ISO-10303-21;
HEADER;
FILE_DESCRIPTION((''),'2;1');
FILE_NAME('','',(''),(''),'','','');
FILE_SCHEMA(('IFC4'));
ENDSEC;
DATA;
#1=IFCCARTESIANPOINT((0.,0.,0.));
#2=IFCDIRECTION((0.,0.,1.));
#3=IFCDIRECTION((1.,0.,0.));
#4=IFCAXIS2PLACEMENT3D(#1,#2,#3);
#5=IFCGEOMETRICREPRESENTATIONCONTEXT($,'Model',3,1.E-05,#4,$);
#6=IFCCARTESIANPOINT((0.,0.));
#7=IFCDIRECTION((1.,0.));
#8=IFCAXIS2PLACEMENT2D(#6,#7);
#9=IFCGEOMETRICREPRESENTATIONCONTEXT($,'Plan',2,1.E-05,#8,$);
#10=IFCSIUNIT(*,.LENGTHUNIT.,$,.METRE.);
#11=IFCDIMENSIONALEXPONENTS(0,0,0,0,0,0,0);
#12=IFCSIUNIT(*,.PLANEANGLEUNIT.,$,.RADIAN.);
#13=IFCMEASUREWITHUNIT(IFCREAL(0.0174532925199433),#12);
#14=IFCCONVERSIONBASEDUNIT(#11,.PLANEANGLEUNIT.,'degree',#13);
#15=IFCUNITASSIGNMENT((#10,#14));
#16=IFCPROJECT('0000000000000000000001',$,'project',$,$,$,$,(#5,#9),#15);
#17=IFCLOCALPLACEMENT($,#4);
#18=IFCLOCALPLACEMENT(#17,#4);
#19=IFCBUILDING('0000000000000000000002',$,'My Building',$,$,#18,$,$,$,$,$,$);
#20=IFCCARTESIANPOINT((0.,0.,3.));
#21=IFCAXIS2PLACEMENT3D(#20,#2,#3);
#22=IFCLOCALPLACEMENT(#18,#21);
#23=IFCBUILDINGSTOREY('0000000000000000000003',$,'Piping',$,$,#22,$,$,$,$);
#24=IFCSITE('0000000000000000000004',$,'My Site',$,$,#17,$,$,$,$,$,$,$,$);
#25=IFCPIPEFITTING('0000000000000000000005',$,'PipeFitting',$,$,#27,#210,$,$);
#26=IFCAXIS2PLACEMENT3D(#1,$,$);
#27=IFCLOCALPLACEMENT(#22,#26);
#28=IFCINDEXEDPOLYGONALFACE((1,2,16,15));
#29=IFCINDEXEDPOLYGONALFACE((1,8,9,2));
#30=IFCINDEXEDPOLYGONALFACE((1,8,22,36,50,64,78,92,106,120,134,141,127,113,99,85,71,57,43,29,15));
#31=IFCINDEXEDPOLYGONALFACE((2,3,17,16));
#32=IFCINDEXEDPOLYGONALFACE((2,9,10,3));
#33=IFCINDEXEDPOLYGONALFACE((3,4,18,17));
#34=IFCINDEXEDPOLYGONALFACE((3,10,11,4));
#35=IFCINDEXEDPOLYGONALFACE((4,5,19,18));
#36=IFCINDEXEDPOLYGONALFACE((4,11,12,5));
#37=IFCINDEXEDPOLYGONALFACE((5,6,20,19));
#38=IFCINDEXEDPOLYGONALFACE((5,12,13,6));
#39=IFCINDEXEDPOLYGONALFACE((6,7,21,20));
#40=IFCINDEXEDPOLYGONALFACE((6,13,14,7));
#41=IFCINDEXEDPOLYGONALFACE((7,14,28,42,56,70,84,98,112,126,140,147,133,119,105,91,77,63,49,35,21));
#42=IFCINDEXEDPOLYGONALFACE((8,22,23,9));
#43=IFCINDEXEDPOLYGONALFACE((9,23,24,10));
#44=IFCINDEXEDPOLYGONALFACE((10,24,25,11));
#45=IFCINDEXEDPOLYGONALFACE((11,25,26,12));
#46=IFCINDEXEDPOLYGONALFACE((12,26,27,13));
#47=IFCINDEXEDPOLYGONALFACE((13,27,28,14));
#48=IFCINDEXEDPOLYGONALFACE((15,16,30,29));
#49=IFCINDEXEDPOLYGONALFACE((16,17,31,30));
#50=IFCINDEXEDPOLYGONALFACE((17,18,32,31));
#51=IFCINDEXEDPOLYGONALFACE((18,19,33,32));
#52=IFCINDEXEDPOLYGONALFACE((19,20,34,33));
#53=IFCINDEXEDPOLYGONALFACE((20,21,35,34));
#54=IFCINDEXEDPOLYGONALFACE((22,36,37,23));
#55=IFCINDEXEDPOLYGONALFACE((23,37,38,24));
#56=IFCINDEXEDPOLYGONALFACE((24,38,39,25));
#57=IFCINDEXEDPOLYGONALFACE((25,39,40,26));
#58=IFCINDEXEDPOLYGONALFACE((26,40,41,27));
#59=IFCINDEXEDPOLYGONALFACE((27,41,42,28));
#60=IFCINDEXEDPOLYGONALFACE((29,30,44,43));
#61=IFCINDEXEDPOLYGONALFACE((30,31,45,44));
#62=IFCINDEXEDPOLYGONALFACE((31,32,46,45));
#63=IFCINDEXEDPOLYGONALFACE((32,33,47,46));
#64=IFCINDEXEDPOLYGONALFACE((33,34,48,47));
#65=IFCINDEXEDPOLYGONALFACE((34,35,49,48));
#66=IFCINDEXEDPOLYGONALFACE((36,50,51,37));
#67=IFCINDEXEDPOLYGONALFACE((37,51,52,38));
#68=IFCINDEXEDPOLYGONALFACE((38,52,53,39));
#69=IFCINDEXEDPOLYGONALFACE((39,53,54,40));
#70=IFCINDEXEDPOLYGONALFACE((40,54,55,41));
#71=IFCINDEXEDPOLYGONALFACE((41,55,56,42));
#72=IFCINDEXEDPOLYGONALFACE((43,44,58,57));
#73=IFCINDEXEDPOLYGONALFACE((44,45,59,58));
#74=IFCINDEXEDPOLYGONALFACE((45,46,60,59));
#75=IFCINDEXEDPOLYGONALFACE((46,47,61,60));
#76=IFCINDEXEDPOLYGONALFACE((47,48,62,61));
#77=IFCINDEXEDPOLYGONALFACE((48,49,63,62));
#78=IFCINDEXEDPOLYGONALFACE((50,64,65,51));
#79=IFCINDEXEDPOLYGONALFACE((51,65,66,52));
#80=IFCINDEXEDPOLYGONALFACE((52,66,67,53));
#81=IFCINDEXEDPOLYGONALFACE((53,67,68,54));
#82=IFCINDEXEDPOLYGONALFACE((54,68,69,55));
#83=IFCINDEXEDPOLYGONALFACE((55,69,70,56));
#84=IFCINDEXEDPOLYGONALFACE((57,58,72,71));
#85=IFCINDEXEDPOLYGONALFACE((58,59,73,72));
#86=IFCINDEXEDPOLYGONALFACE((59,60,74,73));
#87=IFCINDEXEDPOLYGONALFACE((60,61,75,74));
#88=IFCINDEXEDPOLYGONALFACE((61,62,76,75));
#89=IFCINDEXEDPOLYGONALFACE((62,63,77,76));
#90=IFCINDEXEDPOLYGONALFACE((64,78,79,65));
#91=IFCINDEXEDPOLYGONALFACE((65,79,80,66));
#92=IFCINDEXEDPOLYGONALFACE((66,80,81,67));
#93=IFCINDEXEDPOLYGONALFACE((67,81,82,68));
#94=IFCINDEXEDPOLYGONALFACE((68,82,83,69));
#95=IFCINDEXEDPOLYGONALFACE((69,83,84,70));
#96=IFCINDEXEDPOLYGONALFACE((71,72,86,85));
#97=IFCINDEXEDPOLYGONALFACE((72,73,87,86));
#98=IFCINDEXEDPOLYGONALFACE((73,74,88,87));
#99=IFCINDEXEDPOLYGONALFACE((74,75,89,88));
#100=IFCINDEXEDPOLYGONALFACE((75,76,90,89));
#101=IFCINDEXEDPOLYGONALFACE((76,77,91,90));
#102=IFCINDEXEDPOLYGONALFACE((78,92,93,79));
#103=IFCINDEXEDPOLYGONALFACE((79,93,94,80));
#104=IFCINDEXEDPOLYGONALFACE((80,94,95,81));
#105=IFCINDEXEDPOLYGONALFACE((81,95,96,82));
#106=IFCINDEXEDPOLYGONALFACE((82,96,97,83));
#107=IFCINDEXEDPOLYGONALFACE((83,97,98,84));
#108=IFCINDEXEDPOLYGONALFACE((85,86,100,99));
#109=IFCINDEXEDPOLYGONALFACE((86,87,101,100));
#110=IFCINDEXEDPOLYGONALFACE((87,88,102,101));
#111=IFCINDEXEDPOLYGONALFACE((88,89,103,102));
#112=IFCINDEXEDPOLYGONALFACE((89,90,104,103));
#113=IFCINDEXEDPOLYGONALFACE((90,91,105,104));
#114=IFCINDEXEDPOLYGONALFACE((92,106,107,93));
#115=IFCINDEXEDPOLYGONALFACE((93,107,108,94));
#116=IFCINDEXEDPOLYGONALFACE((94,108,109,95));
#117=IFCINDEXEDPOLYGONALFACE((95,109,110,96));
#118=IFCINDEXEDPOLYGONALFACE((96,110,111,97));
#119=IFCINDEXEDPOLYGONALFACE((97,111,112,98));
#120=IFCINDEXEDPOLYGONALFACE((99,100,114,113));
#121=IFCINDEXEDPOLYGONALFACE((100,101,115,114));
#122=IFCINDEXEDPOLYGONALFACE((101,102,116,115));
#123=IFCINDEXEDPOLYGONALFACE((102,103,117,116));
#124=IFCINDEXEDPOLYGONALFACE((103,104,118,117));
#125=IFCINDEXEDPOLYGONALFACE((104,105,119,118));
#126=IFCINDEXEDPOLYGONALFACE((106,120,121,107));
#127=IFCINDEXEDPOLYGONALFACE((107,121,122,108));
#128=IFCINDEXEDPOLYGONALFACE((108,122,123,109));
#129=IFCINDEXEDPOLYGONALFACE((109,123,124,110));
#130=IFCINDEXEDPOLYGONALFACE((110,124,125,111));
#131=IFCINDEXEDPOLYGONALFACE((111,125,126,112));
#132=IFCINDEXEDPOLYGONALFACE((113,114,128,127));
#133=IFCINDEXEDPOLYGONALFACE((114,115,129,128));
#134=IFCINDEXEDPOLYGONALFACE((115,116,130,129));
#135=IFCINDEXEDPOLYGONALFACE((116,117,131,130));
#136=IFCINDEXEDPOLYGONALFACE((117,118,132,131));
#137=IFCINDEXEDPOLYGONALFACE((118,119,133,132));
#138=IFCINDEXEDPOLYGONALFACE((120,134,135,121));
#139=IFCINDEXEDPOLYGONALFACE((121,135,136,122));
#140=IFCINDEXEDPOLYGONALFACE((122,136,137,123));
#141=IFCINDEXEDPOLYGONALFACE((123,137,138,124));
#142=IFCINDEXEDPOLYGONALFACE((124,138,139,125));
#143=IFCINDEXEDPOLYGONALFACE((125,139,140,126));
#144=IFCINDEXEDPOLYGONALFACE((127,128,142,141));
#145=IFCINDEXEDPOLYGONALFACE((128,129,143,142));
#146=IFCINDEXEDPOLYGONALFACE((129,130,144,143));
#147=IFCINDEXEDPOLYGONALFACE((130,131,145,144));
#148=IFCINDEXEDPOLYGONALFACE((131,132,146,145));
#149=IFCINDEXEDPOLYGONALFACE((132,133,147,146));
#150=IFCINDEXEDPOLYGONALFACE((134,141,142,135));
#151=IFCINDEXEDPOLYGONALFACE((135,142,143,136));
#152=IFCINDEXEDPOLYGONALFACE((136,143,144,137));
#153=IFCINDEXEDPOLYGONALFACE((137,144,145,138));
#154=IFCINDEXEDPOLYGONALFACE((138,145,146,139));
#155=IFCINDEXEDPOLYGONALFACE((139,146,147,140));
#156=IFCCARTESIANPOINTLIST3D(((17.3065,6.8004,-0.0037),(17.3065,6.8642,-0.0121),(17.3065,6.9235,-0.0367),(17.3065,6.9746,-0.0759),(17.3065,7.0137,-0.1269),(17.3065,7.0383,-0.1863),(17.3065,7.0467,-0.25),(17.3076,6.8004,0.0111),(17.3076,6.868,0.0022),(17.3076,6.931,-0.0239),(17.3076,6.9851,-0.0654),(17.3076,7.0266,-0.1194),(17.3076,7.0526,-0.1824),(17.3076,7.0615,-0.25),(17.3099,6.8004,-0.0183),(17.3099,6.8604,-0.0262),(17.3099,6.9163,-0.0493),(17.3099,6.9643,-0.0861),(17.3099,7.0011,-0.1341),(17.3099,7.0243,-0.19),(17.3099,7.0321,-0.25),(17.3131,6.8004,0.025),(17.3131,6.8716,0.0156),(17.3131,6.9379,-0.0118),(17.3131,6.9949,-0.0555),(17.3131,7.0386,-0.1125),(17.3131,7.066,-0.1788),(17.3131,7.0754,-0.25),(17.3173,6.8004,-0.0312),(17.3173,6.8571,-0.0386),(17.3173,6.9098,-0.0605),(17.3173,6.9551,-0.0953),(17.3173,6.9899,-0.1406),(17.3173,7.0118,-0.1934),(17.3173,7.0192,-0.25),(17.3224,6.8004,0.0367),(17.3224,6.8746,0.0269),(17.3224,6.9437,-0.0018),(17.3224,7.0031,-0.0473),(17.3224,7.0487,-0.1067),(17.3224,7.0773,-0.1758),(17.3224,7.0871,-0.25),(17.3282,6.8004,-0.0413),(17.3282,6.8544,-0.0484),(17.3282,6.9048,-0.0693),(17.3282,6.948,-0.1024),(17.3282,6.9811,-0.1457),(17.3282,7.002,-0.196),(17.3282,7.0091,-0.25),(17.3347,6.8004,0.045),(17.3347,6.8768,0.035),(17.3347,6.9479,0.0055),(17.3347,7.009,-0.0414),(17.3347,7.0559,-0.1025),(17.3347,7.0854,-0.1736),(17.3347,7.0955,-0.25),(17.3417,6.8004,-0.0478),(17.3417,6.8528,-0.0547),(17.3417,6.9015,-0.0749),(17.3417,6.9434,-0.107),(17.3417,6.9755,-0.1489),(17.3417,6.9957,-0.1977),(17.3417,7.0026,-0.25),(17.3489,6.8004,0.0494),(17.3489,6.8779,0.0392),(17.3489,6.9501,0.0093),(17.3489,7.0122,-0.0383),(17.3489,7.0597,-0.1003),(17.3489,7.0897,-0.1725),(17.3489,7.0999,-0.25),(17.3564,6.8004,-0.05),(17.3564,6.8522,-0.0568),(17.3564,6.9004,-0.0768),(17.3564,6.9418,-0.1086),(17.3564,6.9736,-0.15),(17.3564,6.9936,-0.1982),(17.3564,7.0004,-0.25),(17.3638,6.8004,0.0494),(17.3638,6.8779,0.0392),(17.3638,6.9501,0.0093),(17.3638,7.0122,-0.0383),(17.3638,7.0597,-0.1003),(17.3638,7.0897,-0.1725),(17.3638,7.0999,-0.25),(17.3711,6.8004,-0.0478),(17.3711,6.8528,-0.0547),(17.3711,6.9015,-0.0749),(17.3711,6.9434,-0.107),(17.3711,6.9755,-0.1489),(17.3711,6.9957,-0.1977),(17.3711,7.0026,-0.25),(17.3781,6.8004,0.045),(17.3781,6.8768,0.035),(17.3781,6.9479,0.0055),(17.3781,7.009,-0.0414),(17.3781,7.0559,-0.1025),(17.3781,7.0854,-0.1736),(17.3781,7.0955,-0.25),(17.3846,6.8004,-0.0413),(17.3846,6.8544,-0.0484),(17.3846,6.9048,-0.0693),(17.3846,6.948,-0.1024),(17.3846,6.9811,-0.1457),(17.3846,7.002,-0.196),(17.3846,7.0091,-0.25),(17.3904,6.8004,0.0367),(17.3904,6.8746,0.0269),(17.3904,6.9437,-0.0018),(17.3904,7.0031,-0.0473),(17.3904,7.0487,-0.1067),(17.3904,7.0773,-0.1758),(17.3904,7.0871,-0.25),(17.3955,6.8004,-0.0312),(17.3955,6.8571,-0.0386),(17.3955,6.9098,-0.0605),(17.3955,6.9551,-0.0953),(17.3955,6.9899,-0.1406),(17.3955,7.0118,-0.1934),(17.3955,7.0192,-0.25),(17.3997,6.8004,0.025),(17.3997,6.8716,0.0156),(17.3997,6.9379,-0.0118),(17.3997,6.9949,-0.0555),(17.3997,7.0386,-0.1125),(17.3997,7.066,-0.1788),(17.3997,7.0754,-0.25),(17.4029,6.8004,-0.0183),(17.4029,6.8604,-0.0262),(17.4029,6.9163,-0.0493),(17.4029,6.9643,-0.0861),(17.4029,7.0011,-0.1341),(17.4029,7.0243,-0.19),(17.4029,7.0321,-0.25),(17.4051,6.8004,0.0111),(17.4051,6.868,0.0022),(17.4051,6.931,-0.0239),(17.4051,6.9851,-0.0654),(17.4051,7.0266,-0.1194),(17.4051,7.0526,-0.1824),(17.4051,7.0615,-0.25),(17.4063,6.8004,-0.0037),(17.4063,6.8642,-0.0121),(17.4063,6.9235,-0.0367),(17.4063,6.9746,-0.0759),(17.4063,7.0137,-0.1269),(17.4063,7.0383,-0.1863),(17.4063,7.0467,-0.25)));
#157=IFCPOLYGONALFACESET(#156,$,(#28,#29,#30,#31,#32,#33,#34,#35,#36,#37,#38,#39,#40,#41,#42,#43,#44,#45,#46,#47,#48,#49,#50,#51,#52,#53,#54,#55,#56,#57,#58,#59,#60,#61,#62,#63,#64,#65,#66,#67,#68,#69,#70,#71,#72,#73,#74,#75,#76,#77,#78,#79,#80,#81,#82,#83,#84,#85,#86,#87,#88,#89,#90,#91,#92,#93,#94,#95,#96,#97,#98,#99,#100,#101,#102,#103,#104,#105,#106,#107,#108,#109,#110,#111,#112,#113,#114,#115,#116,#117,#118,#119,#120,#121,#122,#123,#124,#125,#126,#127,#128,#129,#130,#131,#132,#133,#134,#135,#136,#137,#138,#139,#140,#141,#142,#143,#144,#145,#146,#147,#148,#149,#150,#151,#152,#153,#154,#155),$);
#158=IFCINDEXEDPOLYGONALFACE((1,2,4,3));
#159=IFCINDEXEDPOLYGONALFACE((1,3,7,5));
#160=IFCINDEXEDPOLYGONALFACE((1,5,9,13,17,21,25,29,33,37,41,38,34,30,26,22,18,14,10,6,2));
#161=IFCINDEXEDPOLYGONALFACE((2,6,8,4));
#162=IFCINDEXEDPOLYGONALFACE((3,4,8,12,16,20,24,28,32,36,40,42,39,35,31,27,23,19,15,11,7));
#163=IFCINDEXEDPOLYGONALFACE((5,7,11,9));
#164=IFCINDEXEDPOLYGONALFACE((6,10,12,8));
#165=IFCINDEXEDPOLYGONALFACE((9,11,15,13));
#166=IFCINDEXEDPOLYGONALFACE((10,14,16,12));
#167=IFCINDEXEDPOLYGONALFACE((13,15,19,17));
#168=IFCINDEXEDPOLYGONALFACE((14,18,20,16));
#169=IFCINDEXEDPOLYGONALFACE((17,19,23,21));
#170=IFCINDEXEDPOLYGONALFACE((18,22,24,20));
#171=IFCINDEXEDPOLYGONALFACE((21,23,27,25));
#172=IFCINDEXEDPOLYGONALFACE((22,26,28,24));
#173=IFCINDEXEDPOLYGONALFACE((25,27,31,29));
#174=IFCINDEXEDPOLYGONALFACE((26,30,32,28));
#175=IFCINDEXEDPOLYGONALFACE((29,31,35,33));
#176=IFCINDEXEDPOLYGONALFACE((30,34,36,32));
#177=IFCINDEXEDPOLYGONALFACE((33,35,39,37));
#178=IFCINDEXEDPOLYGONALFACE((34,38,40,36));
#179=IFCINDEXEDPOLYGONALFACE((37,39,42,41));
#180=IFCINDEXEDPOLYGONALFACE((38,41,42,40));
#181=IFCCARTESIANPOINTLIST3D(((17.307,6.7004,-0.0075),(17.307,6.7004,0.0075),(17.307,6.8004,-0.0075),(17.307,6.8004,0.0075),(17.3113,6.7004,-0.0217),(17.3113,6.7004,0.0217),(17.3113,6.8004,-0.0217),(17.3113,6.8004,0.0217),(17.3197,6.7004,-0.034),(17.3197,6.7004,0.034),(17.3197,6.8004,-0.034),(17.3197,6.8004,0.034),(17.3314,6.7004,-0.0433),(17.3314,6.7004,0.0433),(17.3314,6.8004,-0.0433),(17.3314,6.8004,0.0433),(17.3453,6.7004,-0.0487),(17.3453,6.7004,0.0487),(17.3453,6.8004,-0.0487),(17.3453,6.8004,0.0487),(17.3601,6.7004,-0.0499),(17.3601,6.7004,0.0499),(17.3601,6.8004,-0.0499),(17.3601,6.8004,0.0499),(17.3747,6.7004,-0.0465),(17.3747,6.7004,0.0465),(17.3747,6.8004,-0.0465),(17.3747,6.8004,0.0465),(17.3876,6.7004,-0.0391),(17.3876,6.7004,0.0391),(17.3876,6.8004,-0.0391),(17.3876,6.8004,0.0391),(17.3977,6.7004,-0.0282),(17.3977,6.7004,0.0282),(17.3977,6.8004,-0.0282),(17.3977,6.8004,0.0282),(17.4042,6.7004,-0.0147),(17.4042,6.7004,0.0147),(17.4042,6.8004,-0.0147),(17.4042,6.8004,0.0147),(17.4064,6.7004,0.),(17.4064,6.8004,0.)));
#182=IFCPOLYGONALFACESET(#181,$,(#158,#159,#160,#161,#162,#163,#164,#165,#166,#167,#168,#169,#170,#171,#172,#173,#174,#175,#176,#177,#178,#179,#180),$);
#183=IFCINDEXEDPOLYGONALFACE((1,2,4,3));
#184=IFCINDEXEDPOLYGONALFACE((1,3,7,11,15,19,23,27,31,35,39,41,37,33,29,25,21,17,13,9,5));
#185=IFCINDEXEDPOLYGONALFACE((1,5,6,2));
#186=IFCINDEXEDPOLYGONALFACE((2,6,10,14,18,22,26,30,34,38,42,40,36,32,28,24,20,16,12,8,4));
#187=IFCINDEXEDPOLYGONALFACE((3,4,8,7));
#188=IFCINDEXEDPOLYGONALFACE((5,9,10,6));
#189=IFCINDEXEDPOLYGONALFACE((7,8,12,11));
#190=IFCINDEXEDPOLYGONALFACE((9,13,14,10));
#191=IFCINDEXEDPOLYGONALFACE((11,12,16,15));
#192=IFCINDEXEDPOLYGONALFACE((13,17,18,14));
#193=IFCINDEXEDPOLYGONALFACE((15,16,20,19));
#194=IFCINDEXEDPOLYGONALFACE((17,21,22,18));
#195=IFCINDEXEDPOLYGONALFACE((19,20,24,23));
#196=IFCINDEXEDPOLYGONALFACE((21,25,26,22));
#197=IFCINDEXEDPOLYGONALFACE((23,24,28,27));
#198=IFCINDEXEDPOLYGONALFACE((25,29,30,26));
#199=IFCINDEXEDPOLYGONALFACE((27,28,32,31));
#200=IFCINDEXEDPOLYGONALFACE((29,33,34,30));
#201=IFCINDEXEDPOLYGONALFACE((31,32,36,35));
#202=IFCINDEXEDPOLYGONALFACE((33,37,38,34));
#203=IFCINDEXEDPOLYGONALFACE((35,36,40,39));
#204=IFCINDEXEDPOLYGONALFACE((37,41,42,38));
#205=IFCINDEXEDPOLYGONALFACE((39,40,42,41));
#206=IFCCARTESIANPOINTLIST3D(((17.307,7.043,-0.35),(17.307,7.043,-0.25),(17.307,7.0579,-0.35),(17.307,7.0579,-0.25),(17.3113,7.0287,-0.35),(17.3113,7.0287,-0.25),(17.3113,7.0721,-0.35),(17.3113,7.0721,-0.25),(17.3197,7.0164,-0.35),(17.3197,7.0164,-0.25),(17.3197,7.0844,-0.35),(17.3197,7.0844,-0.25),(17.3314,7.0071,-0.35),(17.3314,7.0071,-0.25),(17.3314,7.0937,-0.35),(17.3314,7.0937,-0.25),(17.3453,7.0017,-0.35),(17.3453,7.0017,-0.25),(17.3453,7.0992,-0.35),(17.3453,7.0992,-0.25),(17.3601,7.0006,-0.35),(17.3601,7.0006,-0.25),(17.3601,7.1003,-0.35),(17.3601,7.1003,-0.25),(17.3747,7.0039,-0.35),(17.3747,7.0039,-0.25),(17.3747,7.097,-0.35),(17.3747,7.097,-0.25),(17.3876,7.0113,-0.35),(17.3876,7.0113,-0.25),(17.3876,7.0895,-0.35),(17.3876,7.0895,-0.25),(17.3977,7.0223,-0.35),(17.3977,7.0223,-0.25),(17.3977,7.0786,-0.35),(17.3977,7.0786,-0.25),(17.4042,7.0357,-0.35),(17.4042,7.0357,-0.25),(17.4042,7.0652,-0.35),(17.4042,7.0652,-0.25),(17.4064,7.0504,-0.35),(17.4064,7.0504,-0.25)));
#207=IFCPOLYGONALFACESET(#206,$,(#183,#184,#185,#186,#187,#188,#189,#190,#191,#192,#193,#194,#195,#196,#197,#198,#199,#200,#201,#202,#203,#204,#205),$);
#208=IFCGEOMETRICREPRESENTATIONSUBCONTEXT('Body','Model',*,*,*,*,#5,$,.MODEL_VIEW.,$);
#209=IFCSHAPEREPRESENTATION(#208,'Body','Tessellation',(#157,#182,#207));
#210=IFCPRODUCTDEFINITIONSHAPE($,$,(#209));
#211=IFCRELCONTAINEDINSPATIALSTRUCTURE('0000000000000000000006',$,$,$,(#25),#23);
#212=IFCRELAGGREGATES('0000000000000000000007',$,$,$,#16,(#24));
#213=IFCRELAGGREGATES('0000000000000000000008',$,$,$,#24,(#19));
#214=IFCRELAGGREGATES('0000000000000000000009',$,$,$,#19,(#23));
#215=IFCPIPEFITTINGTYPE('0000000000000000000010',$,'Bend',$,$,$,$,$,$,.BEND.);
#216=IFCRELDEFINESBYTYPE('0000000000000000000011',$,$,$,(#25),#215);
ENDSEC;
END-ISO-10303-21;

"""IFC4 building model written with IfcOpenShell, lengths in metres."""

from ifc_helpers import new_model, entity, si_unit, converted_unit, frame, origin_with_axes, origin_2d_with_axis, place, context, subcontext, project, spatial, circle, extrude, source, transform, mapped, type_object, type_shapes, element, save


model = new_model("IFC4")

# Units and contexts
model_context = context("Model", 3, precision=1e-05, world=origin_with_axes())
plan_context = context("Plan", 2, precision=1e-05, world=origin_2d_with_axis())
body_context = subcontext(model_context, "Body", "Model", "MODEL_VIEW")
ifc_project = project(units=[si_unit("LENGTHUNIT", "METRE"), converted_unit("PLANEANGLEUNIT", "degree", entity("IfcReal", 0.0174532925199433), si_unit("PLANEANGLEUNIT", "RADIAN"), dimensions=[0, 0, 0, 0, 0, 0, 0])], contexts=[model_context, plan_context])

# Site, building, storey
site_placement = place(None, origin_with_axes())
site = spatial("IfcSite", under=ifc_project, at=site_placement, Name="My Site")
building_placement = place(site_placement, origin_with_axes())
building = spatial("IfcBuilding", under=site, at=building_placement, Name="My Building")
storey_placement = place(building_placement, frame((0.0, 0.0, 3.0), z_axis=(0.0, 0.0, 1.0), x_axis=(1.0, 0.0, 0.0)))
storey = spatial("IfcBuildingStorey", under=building, at=storey_placement, Name="Piping")

# Pipe fitting
pipe_fitting_type = type_object("IfcPipeFittingType", Name="Bend", PredefinedType="BEND")
shared_shape = source(origin_with_axes(), body_context, "Body", "SolidModel", [
    entity("IfcSweptDiskSolid", entity("IfcIndexedPolyCurve", entity("IfcCartesianPointList3D", [[0.0, 0.0, -0.1], [0.0, -0.0732, -0.2768], [0.0, -0.25, -0.35]]), [entity("IfcArcIndex", [1, 2, 3])]), 0.05),
    extrude(circle(Radius=0.05), origin_with_axes(), (0.0, 0.0, -1.0), 0.1),
    extrude(circle(Radius=0.05), frame((0.0, -0.25, -0.35), z_axis=(0.0, -1.0, 0.0), x_axis=(1.0, 0.0, 0.0)), (0.0, 0.0, 1.0), 0.1),
])
type_shapes(pipe_fitting_type, [shared_shape])
for number, where, z_axis, x_axis, name in (
    (1, (17.3564, 6.7004, 0.0), (0.0, -1.0, 0.0), (1.0, 0.0, 0.0), "PipeFitting"),
):
    element("IfcPipeFitting", number, at=place(storey_placement, frame(where, z_axis=z_axis, x_axis=x_axis)), inside=storey, type_object=pipe_fitting_type, Name=name, context=body_context, shape_type="MappedRepresentation", body=[
        mapped(shared_shape, transform((0.0, 0.0, 0.0), x_axis=(1.0, 0.0, 0.0), y_axis=(0.0, 1.0, 0.0), z_axis=(0.0, 0.0, 1.0), scale=1.0)),
    ])

save(model, "model.ifc")
